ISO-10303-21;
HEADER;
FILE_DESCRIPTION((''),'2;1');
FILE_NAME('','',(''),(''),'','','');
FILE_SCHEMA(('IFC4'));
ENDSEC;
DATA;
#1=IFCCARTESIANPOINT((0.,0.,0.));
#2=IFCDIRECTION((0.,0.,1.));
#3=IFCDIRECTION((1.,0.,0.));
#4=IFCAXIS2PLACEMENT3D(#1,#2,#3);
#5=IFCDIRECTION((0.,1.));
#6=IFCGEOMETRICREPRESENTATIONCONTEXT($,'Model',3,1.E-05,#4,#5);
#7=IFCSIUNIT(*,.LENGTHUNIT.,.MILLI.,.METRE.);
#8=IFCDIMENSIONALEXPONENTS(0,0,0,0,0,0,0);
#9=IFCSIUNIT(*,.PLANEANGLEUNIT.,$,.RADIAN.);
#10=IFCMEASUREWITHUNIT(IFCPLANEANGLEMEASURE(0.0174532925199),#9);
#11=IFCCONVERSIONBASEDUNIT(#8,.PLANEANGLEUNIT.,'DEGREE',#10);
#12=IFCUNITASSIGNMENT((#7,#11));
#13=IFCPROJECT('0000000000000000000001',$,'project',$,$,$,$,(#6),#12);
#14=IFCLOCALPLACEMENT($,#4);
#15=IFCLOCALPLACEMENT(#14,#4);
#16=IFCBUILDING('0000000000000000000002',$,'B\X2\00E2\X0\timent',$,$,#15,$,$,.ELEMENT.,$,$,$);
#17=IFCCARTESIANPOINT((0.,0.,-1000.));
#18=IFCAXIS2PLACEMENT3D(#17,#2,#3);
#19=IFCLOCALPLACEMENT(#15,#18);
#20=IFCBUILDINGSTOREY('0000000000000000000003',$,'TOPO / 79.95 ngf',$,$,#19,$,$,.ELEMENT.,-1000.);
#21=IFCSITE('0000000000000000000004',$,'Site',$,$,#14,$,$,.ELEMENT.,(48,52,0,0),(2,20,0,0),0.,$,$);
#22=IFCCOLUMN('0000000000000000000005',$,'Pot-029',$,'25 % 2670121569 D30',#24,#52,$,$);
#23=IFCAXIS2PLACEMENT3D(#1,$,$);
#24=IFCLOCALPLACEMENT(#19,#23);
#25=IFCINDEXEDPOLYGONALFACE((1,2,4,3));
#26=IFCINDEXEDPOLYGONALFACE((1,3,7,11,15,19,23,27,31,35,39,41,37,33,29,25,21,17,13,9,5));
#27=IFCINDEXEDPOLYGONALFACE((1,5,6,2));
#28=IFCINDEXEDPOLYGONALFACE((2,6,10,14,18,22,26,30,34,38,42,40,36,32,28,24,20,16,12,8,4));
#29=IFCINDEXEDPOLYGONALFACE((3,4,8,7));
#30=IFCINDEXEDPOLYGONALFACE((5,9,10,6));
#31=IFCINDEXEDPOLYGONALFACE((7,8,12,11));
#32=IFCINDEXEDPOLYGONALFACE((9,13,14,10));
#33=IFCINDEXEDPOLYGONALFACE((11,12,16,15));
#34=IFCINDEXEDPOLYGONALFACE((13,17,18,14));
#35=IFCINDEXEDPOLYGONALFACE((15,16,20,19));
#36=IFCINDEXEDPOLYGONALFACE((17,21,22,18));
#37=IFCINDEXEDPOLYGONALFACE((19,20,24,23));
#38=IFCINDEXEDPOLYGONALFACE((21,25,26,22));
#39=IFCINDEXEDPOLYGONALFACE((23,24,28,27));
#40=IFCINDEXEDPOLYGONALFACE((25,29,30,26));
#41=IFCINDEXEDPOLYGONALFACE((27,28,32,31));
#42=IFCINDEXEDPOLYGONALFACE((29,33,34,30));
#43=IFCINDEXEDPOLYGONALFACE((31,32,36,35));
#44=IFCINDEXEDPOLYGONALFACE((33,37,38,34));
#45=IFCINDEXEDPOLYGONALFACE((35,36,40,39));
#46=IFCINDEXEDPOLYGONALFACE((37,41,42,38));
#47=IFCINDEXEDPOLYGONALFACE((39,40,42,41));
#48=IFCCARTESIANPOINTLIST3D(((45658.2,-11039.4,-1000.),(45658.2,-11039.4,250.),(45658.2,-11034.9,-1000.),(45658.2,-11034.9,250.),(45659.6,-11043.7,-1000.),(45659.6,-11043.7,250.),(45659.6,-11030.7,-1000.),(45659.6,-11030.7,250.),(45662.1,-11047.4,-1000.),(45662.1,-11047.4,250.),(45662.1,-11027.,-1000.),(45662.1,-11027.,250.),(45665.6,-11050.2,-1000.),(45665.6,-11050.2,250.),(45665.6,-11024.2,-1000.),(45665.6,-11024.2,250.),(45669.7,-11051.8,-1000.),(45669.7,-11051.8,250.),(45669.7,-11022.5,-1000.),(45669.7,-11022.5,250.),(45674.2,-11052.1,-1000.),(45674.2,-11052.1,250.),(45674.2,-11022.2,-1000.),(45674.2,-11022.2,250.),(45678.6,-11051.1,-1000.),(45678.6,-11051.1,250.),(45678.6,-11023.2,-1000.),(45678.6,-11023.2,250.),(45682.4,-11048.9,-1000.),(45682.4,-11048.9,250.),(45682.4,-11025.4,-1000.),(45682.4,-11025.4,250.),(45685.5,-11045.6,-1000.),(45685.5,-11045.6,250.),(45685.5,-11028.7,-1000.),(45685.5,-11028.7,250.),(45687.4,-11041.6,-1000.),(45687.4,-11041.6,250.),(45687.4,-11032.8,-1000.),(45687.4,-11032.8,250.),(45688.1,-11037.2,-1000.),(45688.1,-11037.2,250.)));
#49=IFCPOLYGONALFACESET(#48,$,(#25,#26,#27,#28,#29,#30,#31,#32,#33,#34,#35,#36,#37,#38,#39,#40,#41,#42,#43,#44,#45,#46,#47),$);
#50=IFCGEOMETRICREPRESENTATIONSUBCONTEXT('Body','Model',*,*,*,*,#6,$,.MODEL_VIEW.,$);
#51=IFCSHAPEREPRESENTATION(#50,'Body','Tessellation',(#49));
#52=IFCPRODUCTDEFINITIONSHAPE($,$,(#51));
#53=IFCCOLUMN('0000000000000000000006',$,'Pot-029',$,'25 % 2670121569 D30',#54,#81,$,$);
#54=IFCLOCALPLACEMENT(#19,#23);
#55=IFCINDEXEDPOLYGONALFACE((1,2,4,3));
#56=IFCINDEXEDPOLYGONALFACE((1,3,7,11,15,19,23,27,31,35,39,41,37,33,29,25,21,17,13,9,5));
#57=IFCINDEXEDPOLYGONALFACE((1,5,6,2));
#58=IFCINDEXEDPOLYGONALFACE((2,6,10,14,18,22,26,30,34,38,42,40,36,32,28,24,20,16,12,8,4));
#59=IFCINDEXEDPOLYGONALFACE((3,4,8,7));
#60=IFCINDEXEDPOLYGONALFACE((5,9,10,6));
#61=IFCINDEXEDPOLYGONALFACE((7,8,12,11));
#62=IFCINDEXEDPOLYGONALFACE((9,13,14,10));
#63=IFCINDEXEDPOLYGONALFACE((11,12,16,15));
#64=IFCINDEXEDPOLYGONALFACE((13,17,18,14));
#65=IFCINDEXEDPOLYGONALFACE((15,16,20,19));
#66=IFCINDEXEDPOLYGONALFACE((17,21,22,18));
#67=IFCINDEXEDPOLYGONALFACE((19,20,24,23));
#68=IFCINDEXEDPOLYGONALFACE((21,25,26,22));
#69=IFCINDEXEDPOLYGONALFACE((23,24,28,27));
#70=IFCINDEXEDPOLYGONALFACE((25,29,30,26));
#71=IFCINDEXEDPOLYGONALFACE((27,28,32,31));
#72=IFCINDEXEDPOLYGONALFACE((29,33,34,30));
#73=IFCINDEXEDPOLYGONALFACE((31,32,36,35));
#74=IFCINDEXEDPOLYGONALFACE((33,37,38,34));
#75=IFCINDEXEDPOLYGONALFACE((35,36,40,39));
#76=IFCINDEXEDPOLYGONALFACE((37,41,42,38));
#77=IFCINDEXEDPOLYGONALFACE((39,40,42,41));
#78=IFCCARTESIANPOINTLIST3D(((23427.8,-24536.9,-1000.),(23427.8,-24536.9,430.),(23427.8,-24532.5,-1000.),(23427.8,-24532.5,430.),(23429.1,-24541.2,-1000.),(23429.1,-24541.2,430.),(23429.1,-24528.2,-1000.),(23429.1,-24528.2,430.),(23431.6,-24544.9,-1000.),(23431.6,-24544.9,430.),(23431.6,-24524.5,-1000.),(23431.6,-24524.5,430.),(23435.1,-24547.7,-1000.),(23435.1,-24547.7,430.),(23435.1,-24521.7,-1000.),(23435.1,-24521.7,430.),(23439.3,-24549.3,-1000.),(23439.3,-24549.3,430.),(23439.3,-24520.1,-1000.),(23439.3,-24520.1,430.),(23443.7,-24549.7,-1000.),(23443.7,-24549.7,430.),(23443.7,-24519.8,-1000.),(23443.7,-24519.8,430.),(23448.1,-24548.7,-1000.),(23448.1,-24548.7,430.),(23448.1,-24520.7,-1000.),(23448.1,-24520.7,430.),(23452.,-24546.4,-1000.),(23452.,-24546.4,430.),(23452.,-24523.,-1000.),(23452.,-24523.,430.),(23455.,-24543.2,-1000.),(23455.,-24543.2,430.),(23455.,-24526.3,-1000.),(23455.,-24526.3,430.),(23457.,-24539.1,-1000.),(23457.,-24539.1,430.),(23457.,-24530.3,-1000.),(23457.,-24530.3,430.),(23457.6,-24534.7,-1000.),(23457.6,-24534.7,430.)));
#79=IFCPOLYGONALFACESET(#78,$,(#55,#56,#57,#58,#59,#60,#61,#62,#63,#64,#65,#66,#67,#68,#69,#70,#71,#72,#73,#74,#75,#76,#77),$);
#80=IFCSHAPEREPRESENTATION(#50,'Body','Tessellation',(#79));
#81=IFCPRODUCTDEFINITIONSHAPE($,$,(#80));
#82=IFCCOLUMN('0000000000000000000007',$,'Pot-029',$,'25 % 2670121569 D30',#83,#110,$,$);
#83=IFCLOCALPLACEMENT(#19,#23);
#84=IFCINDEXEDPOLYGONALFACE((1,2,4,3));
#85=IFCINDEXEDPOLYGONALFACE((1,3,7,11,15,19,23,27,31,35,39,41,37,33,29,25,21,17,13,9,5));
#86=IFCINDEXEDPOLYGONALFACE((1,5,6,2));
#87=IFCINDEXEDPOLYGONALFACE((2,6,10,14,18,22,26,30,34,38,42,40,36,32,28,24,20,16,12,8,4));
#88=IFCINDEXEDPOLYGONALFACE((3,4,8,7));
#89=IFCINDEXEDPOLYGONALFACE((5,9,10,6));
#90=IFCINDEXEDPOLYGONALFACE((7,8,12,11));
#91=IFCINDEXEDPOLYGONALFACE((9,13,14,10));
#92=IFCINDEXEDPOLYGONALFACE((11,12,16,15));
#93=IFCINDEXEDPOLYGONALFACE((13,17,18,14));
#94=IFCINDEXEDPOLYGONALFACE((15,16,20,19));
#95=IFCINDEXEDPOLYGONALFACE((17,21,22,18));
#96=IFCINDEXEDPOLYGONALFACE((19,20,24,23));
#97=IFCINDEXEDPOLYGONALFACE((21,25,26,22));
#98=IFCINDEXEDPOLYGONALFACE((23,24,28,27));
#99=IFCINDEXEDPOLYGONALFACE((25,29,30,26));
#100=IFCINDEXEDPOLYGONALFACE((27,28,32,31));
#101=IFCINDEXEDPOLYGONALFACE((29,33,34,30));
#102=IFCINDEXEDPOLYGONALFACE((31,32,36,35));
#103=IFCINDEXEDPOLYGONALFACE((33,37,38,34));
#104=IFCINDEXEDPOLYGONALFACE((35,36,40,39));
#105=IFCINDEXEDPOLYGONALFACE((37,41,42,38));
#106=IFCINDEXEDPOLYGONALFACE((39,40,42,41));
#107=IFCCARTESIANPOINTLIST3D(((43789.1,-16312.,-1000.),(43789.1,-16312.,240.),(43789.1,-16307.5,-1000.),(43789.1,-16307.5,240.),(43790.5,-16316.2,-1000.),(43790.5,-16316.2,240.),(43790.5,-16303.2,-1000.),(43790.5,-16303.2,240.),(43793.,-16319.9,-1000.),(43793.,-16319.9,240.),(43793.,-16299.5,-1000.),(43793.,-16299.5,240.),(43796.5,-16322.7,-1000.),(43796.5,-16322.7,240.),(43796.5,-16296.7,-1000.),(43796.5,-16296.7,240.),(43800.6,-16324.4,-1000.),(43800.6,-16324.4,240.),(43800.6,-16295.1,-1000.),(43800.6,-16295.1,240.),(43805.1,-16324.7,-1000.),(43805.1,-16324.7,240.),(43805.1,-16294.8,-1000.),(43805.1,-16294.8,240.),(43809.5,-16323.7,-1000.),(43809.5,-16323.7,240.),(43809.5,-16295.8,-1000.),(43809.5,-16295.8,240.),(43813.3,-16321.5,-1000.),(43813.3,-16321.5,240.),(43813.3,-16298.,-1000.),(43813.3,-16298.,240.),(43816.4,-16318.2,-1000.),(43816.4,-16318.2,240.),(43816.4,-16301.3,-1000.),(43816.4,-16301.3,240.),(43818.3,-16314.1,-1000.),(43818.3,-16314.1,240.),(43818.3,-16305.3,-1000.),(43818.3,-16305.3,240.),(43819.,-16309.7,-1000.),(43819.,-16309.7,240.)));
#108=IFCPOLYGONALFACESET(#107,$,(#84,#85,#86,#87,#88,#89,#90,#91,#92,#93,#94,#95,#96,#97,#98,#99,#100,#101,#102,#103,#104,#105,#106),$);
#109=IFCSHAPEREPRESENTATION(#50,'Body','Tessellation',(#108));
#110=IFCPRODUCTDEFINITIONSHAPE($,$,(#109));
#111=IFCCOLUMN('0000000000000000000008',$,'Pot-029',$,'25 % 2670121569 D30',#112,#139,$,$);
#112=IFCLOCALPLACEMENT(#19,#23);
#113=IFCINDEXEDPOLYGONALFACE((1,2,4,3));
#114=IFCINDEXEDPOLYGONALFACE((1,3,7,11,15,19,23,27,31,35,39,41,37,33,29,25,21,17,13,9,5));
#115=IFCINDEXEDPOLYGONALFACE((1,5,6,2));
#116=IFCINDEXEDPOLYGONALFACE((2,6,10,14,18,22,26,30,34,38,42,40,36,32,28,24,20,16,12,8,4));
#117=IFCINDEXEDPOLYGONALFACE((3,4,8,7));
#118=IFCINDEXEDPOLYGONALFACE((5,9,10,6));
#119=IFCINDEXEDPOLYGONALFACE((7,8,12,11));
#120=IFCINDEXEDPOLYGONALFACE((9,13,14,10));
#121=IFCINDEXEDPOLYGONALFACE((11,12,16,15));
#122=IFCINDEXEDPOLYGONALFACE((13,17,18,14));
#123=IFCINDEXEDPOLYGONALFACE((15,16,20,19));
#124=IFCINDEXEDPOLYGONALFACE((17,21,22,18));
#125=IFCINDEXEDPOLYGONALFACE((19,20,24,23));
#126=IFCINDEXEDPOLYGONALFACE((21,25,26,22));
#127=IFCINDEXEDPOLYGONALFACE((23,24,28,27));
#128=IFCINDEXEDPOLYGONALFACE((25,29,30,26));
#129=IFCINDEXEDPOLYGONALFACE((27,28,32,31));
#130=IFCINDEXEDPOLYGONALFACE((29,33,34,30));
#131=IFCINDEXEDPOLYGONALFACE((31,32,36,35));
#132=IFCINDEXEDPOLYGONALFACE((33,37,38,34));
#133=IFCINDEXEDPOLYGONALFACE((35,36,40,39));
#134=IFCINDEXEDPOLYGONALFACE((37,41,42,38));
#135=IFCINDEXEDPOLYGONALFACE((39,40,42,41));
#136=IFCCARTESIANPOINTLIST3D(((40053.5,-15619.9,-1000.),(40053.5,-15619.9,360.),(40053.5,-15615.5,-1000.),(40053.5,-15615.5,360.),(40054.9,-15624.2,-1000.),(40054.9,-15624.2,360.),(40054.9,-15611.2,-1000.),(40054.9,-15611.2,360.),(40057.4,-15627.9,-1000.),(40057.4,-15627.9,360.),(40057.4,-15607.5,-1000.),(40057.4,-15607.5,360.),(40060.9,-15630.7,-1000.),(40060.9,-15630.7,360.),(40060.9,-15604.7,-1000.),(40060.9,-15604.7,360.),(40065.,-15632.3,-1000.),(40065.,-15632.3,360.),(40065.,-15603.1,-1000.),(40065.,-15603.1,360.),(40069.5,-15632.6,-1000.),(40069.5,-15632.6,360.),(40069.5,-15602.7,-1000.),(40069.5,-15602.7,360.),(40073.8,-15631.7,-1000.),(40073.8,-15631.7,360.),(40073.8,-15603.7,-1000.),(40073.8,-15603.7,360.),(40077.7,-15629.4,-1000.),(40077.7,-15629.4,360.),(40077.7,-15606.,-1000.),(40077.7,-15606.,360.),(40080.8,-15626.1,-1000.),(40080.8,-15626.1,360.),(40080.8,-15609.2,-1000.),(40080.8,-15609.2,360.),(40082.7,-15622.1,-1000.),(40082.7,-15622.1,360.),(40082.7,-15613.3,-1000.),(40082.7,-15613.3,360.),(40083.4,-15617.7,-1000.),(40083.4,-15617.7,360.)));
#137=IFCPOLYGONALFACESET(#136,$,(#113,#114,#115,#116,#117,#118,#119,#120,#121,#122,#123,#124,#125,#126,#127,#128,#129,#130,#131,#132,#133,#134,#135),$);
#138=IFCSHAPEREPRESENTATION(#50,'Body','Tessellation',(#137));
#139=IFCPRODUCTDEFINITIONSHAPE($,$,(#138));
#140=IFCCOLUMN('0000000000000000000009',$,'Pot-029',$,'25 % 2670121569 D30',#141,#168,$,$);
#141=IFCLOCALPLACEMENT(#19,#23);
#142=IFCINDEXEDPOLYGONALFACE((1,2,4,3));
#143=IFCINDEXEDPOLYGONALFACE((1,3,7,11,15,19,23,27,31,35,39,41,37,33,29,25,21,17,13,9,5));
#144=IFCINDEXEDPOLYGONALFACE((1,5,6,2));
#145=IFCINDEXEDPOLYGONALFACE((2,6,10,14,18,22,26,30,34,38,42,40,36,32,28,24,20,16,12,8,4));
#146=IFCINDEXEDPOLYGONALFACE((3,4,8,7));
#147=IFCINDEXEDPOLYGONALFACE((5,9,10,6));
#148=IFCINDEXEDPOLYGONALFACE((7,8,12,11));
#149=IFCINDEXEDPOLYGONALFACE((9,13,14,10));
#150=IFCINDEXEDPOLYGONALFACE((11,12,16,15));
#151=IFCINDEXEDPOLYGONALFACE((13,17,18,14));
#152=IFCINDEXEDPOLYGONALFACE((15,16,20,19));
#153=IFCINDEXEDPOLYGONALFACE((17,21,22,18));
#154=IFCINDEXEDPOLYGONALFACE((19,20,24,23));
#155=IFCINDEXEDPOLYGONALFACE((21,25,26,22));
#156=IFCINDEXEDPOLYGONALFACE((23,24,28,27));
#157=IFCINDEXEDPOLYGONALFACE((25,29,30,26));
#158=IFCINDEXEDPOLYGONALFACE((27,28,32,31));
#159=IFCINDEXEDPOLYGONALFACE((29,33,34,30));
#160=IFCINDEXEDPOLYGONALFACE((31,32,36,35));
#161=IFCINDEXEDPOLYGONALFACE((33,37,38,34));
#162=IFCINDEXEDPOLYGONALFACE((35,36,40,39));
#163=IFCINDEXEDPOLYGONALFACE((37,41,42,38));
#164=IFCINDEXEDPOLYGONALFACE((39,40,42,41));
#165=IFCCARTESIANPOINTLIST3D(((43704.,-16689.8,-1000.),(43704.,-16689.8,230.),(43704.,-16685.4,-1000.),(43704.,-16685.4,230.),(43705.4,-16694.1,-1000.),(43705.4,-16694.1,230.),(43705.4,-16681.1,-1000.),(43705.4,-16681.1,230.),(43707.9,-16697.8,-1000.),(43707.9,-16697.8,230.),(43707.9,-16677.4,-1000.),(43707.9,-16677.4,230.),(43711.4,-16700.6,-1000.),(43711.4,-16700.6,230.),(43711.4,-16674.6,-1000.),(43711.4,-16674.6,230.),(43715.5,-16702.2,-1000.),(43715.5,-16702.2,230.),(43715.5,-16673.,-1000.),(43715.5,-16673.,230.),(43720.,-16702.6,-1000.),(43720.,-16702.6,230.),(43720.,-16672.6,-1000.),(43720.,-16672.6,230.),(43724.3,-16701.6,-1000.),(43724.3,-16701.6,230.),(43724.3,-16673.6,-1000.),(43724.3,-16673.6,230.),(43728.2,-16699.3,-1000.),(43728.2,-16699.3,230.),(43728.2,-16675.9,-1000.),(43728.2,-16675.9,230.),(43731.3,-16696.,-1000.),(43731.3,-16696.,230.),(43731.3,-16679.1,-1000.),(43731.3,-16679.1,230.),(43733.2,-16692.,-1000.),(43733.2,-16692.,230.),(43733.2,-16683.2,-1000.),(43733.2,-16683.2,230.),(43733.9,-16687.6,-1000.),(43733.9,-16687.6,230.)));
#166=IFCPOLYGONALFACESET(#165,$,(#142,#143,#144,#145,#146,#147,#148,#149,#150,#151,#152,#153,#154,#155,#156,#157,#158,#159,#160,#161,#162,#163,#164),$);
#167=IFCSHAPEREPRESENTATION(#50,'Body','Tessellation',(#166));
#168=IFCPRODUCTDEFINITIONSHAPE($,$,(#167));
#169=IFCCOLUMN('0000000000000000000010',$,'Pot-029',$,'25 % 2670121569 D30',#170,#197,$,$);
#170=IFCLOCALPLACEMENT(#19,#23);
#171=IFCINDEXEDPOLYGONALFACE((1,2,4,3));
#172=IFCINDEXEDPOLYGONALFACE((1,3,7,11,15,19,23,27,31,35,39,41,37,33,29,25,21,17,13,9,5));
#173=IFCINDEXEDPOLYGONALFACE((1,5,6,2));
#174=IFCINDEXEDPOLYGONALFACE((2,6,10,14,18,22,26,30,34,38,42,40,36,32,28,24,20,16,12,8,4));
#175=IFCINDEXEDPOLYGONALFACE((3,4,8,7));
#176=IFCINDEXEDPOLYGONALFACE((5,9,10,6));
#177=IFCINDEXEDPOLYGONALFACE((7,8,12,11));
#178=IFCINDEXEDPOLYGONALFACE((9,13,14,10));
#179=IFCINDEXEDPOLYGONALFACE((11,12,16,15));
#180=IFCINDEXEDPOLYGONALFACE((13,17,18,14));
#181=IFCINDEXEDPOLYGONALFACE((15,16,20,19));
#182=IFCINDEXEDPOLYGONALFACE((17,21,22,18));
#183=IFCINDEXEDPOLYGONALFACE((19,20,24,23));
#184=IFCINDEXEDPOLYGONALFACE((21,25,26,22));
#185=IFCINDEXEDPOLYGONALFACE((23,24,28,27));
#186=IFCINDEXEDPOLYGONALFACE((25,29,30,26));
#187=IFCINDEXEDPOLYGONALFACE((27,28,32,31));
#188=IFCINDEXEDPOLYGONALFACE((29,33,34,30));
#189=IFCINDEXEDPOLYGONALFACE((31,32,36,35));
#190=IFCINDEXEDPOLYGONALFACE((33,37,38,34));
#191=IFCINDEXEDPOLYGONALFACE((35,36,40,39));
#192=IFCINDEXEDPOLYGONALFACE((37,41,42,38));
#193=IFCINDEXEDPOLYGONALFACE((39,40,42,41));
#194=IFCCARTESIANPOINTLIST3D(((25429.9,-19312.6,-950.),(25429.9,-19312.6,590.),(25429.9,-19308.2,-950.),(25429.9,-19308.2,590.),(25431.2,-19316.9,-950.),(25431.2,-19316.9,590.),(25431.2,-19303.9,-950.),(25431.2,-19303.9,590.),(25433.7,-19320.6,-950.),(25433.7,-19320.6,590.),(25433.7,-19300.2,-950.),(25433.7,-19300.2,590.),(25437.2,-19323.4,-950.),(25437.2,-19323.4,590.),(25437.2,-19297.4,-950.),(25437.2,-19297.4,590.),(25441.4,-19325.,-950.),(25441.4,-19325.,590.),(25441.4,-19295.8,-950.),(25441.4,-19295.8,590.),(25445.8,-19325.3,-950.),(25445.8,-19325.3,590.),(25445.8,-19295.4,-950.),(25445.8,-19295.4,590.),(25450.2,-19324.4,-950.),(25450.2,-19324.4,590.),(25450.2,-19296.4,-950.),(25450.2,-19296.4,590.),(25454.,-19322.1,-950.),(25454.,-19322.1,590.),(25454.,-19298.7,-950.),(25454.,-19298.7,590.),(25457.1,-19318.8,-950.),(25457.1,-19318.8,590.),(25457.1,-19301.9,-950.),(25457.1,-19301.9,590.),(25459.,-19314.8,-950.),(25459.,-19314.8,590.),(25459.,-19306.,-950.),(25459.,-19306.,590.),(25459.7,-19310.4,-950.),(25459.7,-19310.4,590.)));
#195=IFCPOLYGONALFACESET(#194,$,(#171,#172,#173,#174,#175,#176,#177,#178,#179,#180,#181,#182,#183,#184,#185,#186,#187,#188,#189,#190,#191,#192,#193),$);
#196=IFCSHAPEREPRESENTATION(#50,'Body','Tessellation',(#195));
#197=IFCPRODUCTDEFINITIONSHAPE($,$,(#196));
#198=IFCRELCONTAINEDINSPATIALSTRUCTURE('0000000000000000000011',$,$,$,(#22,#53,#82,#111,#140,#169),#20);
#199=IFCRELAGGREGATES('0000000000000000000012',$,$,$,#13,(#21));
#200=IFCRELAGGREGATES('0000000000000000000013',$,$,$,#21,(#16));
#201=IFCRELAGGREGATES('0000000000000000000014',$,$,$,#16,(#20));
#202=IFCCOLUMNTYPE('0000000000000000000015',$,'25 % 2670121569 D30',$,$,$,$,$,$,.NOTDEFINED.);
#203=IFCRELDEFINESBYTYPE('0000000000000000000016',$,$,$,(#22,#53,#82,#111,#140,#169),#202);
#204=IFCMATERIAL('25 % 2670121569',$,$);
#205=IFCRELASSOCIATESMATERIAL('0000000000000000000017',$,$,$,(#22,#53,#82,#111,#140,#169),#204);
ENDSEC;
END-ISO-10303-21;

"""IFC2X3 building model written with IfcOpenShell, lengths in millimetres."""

from ifc_helpers import new_model, entity, si_unit, converted_unit, direction, frame, origin_with_axes, origin_2d_with_axis, place, context, subcontext, project, spatial, circle, extrude, material, type_object, element, save


model = new_model("IFC2X3")

# Units and contexts
model_context = context("Model", 3, precision=1e-05, world=origin_with_axes(), true_north=direction((0.0, 1.0)))
body_context = subcontext(model_context, "Body", "Model", "MODEL_VIEW")
ifc_project = project(units=[si_unit("LENGTHUNIT", "METRE", prefix="MILLI"), converted_unit("PLANEANGLEUNIT", "DEGREE", entity("IfcPlaneAngleMeasure", 0.0174532925199), si_unit("PLANEANGLEUNIT", "RADIAN"), dimensions=[0, 0, 0, 0, 0, 0, 0])], contexts=[model_context])

# Site, building, storey
site_placement = place(None, origin_with_axes())
site = spatial("IfcSite", under=ifc_project, at=site_placement, Name="Site", CompositionType="ELEMENT", RefLatitude=(48, 52, 0, 0), RefLongitude=(2, 20, 0, 0), RefElevation=0.0)
building_placement = place(site_placement, origin_with_axes())
building = spatial("IfcBuilding", under=site, at=building_placement, Name="Bâtiment", CompositionType="ELEMENT")
storey_placement = place(building_placement, frame((0.0, 0.0, -1000.0), z_axis=(0.0, 0.0, 1.0), x_axis=(1.0, 0.0, 0.0)))
storey = spatial("IfcBuildingStorey", under=building, at=storey_placement, Name="TOPO / 79.95 ngf", CompositionType="ELEMENT", Elevation=-1000.0)

# Columns
ifc_material_1 = material(Name="25 % 2670121569")
column_type_1 = type_object("IfcColumnType", Name="25 % 2670121569 D30", PredefinedType="NOTDEFINED")
column_1_placement = place(storey_placement, frame((45673.1, -11037.2, -1000.0), z_axis=(0.0, 0.0, 1.0), x_axis=(1.0, 0.0, 0.0)))
element("IfcColumn", 1, at=column_1_placement, inside=storey, type_object=column_type_1, material=ifc_material_1, Name="Pot-029", ObjectType="25 % 2670121569 D30", context=body_context, shape_type="SweptSolid", body=[
    extrude(circle(Radius=15.0, at=origin_2d_with_axis()), origin_with_axes(), (0.0, 0.0, 1.0), 1250.0),
])
column_2_placement = place(storey_placement, frame((23442.6, -24534.7, -1000.0), z_axis=(0.0, 0.0, 1.0), x_axis=(1.0, 0.0, 0.0)))
element("IfcColumn", 2, at=column_2_placement, inside=storey, type_object=column_type_1, material=ifc_material_1, Name="Pot-029", ObjectType="25 % 2670121569 D30", context=body_context, shape_type="SweptSolid", body=[
    extrude(circle(Radius=15.0, at=origin_2d_with_axis()), origin_with_axes(), (0.0, 0.0, 1.0), 1430.0),
])
column_3_placement = place(storey_placement, frame((43804.0, -16309.7, -1000.0), z_axis=(0.0, 0.0, 1.0), x_axis=(1.0, 0.0, 0.0)))
element("IfcColumn", 3, at=column_3_placement, inside=storey, type_object=column_type_1, material=ifc_material_1, Name="Pot-029", ObjectType="25 % 2670121569 D30", context=body_context, shape_type="SweptSolid", body=[
    extrude(circle(Radius=15.0, at=origin_2d_with_axis()), origin_with_axes(), (0.0, 0.0, 1.0), 1240.0),
])
column_4_placement = place(storey_placement, frame((40068.4, -15617.7, -1000.0), z_axis=(0.0, 0.0, 1.0), x_axis=(1.0, 0.0, 0.0)))
element("IfcColumn", 4, at=column_4_placement, inside=storey, type_object=column_type_1, material=ifc_material_1, Name="Pot-029", ObjectType="25 % 2670121569 D30", context=body_context, shape_type="SweptSolid", body=[
    extrude(circle(Radius=15.0, at=origin_2d_with_axis()), origin_with_axes(), (0.0, 0.0, 1.0), 1360.0),
])
column_5_placement = place(storey_placement, frame((43718.9, -16687.6, -1000.0), z_axis=(0.0, 0.0, 1.0), x_axis=(1.0, 0.0, 0.0)))
element("IfcColumn", 5, at=column_5_placement, inside=storey, type_object=column_type_1, material=ifc_material_1, Name="Pot-029", ObjectType="25 % 2670121569 D30", context=body_context, shape_type="SweptSolid", body=[
    extrude(circle(Radius=15.0, at=origin_2d_with_axis()), origin_with_axes(), (0.0, 0.0, 1.0), 1230.0),
])
column_6_placement = place(storey_placement, frame((25444.7, -19310.4, -950.0), z_axis=(0.0, 0.0, 1.0), x_axis=(1.0, 0.0, 0.0)))
element("IfcColumn", 6, at=column_6_placement, inside=storey, type_object=column_type_1, material=ifc_material_1, Name="Pot-029", ObjectType="25 % 2670121569 D30", context=body_context, shape_type="SweptSolid", body=[
    extrude(circle(Radius=15.0, at=origin_2d_with_axis()), origin_with_axes(), (0.0, 0.0, 1.0), 1540.0),
])

save(model, "model.ifc")
